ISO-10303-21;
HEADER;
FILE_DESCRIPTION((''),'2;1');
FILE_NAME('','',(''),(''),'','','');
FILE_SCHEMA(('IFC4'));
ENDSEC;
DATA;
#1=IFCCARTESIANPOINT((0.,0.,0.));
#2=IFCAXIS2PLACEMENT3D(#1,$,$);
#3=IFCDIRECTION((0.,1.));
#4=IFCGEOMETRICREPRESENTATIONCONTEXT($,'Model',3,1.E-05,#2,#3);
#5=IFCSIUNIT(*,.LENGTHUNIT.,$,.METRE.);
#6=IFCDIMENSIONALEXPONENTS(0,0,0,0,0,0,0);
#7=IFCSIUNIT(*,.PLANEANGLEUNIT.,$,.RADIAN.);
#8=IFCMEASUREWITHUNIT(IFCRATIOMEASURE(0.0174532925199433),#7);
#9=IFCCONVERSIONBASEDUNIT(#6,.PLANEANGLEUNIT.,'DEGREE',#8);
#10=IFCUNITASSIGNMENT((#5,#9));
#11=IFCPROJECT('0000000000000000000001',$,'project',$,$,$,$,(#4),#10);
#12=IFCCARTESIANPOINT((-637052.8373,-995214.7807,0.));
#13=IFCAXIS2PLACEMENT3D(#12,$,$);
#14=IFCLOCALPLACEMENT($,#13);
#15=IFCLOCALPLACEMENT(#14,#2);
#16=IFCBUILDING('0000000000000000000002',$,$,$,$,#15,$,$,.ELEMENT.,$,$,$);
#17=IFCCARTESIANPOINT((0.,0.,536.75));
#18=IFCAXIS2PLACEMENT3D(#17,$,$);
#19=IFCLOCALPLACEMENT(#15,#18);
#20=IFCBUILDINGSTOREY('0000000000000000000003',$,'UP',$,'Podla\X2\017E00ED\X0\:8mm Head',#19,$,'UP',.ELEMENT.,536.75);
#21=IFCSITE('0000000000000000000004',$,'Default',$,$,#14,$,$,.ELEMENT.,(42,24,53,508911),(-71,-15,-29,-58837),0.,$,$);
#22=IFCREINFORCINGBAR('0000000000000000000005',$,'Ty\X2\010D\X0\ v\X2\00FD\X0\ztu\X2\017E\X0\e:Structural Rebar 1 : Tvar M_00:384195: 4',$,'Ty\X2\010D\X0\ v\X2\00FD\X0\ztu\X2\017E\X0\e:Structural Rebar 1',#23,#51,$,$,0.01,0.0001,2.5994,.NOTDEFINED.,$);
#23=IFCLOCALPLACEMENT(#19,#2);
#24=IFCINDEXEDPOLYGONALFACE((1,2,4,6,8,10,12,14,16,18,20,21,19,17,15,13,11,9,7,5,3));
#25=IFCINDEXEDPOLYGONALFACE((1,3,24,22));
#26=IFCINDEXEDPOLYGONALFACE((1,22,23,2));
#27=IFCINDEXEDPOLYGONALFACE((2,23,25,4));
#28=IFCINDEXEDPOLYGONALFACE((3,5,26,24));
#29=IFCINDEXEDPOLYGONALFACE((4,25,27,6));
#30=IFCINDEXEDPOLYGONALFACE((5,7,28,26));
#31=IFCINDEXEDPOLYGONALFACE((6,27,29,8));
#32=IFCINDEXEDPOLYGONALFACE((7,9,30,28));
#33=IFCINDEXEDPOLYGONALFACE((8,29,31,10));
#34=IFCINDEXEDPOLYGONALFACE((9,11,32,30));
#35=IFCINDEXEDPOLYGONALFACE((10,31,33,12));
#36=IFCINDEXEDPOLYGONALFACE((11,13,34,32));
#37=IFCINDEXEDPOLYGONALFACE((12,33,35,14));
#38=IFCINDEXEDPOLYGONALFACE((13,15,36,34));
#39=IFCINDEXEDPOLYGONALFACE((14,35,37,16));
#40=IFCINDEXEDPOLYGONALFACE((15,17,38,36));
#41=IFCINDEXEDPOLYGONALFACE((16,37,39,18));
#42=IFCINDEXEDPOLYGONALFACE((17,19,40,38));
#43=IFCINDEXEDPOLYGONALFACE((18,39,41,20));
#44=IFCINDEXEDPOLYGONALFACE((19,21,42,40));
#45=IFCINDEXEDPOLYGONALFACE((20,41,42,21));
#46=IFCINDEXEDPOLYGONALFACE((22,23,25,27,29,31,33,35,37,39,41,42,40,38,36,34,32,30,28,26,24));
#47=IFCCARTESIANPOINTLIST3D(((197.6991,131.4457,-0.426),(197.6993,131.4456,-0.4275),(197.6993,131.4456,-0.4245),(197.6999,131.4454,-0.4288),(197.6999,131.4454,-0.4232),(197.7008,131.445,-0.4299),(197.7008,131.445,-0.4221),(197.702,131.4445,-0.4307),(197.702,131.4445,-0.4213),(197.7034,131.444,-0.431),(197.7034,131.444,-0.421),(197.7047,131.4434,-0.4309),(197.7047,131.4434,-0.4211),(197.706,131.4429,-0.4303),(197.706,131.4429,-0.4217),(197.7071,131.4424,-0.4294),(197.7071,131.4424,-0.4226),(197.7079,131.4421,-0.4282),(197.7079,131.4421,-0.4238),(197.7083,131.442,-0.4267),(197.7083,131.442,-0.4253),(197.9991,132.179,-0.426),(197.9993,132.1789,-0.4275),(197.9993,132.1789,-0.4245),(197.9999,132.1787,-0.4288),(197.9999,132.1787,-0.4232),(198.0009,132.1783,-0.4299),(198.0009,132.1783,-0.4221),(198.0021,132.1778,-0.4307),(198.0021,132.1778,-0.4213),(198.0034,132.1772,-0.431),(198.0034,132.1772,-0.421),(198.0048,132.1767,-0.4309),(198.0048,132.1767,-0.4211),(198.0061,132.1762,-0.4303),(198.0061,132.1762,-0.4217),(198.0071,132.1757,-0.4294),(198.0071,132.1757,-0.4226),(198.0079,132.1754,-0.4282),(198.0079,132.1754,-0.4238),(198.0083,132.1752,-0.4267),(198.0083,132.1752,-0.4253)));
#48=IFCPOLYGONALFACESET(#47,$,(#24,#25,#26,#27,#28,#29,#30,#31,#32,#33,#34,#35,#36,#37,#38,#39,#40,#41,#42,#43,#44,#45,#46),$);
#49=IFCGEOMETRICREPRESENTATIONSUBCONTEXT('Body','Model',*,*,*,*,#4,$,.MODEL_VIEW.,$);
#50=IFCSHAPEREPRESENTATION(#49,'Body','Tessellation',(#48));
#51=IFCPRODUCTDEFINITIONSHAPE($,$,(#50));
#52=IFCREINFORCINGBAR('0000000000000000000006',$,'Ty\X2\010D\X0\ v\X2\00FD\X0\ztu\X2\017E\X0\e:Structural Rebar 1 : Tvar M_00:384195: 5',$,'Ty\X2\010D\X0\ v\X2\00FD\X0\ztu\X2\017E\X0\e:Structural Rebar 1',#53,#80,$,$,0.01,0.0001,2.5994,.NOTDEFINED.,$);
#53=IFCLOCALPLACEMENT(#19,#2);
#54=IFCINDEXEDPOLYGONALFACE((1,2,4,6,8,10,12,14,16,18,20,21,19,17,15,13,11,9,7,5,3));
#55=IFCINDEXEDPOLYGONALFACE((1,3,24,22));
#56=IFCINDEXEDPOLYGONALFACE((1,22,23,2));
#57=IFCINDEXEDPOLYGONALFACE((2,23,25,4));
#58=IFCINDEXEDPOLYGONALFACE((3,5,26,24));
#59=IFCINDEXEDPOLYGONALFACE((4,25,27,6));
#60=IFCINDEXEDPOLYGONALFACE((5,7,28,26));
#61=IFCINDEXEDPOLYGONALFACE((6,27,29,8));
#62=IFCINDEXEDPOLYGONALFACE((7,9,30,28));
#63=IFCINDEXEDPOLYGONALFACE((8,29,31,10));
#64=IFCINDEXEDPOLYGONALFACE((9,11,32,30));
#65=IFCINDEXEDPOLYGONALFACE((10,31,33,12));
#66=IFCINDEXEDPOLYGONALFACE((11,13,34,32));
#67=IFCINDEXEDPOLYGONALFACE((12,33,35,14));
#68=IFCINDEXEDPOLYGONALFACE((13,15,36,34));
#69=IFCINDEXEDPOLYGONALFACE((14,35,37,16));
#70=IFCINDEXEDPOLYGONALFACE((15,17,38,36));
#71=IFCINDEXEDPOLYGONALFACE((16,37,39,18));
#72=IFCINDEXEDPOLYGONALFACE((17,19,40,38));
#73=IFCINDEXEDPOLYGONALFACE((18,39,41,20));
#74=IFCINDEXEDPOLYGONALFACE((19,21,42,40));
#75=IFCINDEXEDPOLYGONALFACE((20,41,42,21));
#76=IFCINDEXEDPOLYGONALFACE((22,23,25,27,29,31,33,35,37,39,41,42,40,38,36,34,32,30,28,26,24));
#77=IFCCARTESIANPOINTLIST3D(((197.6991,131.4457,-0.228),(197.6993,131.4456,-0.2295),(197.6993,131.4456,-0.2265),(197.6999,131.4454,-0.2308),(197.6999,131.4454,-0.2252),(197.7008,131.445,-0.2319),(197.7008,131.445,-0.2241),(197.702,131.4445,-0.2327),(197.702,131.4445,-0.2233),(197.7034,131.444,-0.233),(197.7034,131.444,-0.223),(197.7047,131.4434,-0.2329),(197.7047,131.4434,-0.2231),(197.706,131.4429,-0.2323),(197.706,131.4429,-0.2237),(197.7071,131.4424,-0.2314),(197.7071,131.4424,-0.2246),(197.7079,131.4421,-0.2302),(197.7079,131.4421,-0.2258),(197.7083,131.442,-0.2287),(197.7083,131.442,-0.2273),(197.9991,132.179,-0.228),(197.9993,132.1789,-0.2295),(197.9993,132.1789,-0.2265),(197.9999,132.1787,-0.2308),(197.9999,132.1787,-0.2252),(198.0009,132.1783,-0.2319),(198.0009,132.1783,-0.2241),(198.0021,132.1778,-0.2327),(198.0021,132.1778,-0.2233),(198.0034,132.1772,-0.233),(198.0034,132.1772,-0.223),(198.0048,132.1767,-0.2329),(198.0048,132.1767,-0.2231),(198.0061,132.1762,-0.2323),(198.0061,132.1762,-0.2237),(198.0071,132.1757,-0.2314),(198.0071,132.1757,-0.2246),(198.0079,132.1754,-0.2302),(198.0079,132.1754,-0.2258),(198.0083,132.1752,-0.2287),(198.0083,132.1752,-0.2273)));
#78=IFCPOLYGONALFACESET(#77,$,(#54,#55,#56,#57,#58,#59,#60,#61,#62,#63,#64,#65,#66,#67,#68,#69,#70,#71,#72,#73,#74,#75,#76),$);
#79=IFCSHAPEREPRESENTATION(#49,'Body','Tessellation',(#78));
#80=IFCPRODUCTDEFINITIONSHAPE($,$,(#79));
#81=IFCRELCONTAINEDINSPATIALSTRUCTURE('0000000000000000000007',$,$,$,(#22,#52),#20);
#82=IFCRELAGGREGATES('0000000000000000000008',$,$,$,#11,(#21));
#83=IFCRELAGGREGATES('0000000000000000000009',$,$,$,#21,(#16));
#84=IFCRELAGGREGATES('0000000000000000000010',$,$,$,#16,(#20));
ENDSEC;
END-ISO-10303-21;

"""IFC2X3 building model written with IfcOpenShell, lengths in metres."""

from ifc_helpers import new_model, entity, si_unit, converted_unit, direction, frame, origin, place, context, subcontext, project, spatial, element, save


model = new_model("IFC2X3")

# Units and contexts
model_context = context("Model", 3, precision=1e-05, world=origin(), true_north=direction((0.0, 1.0)))
body_context = subcontext(model_context, "Body", "Model", "MODEL_VIEW")
ifc_project = project(units=[si_unit("LENGTHUNIT", "METRE"), converted_unit("PLANEANGLEUNIT", "DEGREE", entity("IfcRatioMeasure", 0.0174532925199433), si_unit("PLANEANGLEUNIT", "RADIAN"), dimensions=[0, 0, 0, 0, 0, 0, 0])], contexts=[model_context])

# Site, building, storey
site_placement = place(None, frame((-637052.8373, -995214.7807, 0.0)))
site = spatial("IfcSite", under=ifc_project, at=site_placement, Name="Default", CompositionType="ELEMENT", RefLatitude=(42, 24, 53, 508911), RefLongitude=(-71, -15, -29, -58837), RefElevation=0.0)
building_placement = place(site_placement, origin())
building = spatial("IfcBuilding", under=site, at=building_placement, CompositionType="ELEMENT")
storey_placement = place(building_placement, frame((0.0, 0.0, 536.75)))
storey = spatial("IfcBuildingStorey", under=building, at=storey_placement, Name="UP", ObjectType="Podlaží:8mm Head", LongName="UP", CompositionType="ELEMENT", Elevation=536.75)

# Reinforcing bars
reinforcing_bar_1_placement = place(storey_placement, origin())
element("IfcReinforcingBar", 1, at=reinforcing_bar_1_placement, inside=storey, Name="Tyč výztuže:Structural Rebar 1 : Tvar M_00:384195: 4", ObjectType="Tyč výztuže:Structural Rebar 1", BarLength=2.5994, BarRole="NOTDEFINED", CrossSectionArea=0.0001, NominalDiameter=0.01, context=body_context, shape_type="AdvancedSweptSolid", body=[
    entity("IfcSweptDiskSolid", entity("IfcCompositeCurve", [entity("IfcCompositeCurveSegment", "CONTINUOUS", True, entity("IfcPolyline", [entity("IfcCartesianPoint", [-197.7037, -131.4438, 0.426]), entity("IfcCartesianPoint", [-198.0038, -132.1771, 0.426])]))], False), 0.005, None, 0.0, 1.0),
])
reinforcing_bar_2_placement = place(storey_placement, origin())
element("IfcReinforcingBar", 2, at=reinforcing_bar_2_placement, inside=storey, Name="Tyč výztuže:Structural Rebar 1 : Tvar M_00:384195: 5", ObjectType="Tyč výztuže:Structural Rebar 1", BarLength=2.5994, BarRole="NOTDEFINED", CrossSectionArea=0.0001, NominalDiameter=0.01, context=body_context, shape_type="AdvancedSweptSolid", body=[
    entity("IfcSweptDiskSolid", entity("IfcCompositeCurve", [entity("IfcCompositeCurveSegment", "CONTINUOUS", True, entity("IfcPolyline", [entity("IfcCartesianPoint", [-197.7037, -131.4438, 0.228]), entity("IfcCartesianPoint", [-198.0038, -132.1771, 0.228])]))], False), 0.005, None, 0.0, 1.0),
])

save(model, "model.ifc")
